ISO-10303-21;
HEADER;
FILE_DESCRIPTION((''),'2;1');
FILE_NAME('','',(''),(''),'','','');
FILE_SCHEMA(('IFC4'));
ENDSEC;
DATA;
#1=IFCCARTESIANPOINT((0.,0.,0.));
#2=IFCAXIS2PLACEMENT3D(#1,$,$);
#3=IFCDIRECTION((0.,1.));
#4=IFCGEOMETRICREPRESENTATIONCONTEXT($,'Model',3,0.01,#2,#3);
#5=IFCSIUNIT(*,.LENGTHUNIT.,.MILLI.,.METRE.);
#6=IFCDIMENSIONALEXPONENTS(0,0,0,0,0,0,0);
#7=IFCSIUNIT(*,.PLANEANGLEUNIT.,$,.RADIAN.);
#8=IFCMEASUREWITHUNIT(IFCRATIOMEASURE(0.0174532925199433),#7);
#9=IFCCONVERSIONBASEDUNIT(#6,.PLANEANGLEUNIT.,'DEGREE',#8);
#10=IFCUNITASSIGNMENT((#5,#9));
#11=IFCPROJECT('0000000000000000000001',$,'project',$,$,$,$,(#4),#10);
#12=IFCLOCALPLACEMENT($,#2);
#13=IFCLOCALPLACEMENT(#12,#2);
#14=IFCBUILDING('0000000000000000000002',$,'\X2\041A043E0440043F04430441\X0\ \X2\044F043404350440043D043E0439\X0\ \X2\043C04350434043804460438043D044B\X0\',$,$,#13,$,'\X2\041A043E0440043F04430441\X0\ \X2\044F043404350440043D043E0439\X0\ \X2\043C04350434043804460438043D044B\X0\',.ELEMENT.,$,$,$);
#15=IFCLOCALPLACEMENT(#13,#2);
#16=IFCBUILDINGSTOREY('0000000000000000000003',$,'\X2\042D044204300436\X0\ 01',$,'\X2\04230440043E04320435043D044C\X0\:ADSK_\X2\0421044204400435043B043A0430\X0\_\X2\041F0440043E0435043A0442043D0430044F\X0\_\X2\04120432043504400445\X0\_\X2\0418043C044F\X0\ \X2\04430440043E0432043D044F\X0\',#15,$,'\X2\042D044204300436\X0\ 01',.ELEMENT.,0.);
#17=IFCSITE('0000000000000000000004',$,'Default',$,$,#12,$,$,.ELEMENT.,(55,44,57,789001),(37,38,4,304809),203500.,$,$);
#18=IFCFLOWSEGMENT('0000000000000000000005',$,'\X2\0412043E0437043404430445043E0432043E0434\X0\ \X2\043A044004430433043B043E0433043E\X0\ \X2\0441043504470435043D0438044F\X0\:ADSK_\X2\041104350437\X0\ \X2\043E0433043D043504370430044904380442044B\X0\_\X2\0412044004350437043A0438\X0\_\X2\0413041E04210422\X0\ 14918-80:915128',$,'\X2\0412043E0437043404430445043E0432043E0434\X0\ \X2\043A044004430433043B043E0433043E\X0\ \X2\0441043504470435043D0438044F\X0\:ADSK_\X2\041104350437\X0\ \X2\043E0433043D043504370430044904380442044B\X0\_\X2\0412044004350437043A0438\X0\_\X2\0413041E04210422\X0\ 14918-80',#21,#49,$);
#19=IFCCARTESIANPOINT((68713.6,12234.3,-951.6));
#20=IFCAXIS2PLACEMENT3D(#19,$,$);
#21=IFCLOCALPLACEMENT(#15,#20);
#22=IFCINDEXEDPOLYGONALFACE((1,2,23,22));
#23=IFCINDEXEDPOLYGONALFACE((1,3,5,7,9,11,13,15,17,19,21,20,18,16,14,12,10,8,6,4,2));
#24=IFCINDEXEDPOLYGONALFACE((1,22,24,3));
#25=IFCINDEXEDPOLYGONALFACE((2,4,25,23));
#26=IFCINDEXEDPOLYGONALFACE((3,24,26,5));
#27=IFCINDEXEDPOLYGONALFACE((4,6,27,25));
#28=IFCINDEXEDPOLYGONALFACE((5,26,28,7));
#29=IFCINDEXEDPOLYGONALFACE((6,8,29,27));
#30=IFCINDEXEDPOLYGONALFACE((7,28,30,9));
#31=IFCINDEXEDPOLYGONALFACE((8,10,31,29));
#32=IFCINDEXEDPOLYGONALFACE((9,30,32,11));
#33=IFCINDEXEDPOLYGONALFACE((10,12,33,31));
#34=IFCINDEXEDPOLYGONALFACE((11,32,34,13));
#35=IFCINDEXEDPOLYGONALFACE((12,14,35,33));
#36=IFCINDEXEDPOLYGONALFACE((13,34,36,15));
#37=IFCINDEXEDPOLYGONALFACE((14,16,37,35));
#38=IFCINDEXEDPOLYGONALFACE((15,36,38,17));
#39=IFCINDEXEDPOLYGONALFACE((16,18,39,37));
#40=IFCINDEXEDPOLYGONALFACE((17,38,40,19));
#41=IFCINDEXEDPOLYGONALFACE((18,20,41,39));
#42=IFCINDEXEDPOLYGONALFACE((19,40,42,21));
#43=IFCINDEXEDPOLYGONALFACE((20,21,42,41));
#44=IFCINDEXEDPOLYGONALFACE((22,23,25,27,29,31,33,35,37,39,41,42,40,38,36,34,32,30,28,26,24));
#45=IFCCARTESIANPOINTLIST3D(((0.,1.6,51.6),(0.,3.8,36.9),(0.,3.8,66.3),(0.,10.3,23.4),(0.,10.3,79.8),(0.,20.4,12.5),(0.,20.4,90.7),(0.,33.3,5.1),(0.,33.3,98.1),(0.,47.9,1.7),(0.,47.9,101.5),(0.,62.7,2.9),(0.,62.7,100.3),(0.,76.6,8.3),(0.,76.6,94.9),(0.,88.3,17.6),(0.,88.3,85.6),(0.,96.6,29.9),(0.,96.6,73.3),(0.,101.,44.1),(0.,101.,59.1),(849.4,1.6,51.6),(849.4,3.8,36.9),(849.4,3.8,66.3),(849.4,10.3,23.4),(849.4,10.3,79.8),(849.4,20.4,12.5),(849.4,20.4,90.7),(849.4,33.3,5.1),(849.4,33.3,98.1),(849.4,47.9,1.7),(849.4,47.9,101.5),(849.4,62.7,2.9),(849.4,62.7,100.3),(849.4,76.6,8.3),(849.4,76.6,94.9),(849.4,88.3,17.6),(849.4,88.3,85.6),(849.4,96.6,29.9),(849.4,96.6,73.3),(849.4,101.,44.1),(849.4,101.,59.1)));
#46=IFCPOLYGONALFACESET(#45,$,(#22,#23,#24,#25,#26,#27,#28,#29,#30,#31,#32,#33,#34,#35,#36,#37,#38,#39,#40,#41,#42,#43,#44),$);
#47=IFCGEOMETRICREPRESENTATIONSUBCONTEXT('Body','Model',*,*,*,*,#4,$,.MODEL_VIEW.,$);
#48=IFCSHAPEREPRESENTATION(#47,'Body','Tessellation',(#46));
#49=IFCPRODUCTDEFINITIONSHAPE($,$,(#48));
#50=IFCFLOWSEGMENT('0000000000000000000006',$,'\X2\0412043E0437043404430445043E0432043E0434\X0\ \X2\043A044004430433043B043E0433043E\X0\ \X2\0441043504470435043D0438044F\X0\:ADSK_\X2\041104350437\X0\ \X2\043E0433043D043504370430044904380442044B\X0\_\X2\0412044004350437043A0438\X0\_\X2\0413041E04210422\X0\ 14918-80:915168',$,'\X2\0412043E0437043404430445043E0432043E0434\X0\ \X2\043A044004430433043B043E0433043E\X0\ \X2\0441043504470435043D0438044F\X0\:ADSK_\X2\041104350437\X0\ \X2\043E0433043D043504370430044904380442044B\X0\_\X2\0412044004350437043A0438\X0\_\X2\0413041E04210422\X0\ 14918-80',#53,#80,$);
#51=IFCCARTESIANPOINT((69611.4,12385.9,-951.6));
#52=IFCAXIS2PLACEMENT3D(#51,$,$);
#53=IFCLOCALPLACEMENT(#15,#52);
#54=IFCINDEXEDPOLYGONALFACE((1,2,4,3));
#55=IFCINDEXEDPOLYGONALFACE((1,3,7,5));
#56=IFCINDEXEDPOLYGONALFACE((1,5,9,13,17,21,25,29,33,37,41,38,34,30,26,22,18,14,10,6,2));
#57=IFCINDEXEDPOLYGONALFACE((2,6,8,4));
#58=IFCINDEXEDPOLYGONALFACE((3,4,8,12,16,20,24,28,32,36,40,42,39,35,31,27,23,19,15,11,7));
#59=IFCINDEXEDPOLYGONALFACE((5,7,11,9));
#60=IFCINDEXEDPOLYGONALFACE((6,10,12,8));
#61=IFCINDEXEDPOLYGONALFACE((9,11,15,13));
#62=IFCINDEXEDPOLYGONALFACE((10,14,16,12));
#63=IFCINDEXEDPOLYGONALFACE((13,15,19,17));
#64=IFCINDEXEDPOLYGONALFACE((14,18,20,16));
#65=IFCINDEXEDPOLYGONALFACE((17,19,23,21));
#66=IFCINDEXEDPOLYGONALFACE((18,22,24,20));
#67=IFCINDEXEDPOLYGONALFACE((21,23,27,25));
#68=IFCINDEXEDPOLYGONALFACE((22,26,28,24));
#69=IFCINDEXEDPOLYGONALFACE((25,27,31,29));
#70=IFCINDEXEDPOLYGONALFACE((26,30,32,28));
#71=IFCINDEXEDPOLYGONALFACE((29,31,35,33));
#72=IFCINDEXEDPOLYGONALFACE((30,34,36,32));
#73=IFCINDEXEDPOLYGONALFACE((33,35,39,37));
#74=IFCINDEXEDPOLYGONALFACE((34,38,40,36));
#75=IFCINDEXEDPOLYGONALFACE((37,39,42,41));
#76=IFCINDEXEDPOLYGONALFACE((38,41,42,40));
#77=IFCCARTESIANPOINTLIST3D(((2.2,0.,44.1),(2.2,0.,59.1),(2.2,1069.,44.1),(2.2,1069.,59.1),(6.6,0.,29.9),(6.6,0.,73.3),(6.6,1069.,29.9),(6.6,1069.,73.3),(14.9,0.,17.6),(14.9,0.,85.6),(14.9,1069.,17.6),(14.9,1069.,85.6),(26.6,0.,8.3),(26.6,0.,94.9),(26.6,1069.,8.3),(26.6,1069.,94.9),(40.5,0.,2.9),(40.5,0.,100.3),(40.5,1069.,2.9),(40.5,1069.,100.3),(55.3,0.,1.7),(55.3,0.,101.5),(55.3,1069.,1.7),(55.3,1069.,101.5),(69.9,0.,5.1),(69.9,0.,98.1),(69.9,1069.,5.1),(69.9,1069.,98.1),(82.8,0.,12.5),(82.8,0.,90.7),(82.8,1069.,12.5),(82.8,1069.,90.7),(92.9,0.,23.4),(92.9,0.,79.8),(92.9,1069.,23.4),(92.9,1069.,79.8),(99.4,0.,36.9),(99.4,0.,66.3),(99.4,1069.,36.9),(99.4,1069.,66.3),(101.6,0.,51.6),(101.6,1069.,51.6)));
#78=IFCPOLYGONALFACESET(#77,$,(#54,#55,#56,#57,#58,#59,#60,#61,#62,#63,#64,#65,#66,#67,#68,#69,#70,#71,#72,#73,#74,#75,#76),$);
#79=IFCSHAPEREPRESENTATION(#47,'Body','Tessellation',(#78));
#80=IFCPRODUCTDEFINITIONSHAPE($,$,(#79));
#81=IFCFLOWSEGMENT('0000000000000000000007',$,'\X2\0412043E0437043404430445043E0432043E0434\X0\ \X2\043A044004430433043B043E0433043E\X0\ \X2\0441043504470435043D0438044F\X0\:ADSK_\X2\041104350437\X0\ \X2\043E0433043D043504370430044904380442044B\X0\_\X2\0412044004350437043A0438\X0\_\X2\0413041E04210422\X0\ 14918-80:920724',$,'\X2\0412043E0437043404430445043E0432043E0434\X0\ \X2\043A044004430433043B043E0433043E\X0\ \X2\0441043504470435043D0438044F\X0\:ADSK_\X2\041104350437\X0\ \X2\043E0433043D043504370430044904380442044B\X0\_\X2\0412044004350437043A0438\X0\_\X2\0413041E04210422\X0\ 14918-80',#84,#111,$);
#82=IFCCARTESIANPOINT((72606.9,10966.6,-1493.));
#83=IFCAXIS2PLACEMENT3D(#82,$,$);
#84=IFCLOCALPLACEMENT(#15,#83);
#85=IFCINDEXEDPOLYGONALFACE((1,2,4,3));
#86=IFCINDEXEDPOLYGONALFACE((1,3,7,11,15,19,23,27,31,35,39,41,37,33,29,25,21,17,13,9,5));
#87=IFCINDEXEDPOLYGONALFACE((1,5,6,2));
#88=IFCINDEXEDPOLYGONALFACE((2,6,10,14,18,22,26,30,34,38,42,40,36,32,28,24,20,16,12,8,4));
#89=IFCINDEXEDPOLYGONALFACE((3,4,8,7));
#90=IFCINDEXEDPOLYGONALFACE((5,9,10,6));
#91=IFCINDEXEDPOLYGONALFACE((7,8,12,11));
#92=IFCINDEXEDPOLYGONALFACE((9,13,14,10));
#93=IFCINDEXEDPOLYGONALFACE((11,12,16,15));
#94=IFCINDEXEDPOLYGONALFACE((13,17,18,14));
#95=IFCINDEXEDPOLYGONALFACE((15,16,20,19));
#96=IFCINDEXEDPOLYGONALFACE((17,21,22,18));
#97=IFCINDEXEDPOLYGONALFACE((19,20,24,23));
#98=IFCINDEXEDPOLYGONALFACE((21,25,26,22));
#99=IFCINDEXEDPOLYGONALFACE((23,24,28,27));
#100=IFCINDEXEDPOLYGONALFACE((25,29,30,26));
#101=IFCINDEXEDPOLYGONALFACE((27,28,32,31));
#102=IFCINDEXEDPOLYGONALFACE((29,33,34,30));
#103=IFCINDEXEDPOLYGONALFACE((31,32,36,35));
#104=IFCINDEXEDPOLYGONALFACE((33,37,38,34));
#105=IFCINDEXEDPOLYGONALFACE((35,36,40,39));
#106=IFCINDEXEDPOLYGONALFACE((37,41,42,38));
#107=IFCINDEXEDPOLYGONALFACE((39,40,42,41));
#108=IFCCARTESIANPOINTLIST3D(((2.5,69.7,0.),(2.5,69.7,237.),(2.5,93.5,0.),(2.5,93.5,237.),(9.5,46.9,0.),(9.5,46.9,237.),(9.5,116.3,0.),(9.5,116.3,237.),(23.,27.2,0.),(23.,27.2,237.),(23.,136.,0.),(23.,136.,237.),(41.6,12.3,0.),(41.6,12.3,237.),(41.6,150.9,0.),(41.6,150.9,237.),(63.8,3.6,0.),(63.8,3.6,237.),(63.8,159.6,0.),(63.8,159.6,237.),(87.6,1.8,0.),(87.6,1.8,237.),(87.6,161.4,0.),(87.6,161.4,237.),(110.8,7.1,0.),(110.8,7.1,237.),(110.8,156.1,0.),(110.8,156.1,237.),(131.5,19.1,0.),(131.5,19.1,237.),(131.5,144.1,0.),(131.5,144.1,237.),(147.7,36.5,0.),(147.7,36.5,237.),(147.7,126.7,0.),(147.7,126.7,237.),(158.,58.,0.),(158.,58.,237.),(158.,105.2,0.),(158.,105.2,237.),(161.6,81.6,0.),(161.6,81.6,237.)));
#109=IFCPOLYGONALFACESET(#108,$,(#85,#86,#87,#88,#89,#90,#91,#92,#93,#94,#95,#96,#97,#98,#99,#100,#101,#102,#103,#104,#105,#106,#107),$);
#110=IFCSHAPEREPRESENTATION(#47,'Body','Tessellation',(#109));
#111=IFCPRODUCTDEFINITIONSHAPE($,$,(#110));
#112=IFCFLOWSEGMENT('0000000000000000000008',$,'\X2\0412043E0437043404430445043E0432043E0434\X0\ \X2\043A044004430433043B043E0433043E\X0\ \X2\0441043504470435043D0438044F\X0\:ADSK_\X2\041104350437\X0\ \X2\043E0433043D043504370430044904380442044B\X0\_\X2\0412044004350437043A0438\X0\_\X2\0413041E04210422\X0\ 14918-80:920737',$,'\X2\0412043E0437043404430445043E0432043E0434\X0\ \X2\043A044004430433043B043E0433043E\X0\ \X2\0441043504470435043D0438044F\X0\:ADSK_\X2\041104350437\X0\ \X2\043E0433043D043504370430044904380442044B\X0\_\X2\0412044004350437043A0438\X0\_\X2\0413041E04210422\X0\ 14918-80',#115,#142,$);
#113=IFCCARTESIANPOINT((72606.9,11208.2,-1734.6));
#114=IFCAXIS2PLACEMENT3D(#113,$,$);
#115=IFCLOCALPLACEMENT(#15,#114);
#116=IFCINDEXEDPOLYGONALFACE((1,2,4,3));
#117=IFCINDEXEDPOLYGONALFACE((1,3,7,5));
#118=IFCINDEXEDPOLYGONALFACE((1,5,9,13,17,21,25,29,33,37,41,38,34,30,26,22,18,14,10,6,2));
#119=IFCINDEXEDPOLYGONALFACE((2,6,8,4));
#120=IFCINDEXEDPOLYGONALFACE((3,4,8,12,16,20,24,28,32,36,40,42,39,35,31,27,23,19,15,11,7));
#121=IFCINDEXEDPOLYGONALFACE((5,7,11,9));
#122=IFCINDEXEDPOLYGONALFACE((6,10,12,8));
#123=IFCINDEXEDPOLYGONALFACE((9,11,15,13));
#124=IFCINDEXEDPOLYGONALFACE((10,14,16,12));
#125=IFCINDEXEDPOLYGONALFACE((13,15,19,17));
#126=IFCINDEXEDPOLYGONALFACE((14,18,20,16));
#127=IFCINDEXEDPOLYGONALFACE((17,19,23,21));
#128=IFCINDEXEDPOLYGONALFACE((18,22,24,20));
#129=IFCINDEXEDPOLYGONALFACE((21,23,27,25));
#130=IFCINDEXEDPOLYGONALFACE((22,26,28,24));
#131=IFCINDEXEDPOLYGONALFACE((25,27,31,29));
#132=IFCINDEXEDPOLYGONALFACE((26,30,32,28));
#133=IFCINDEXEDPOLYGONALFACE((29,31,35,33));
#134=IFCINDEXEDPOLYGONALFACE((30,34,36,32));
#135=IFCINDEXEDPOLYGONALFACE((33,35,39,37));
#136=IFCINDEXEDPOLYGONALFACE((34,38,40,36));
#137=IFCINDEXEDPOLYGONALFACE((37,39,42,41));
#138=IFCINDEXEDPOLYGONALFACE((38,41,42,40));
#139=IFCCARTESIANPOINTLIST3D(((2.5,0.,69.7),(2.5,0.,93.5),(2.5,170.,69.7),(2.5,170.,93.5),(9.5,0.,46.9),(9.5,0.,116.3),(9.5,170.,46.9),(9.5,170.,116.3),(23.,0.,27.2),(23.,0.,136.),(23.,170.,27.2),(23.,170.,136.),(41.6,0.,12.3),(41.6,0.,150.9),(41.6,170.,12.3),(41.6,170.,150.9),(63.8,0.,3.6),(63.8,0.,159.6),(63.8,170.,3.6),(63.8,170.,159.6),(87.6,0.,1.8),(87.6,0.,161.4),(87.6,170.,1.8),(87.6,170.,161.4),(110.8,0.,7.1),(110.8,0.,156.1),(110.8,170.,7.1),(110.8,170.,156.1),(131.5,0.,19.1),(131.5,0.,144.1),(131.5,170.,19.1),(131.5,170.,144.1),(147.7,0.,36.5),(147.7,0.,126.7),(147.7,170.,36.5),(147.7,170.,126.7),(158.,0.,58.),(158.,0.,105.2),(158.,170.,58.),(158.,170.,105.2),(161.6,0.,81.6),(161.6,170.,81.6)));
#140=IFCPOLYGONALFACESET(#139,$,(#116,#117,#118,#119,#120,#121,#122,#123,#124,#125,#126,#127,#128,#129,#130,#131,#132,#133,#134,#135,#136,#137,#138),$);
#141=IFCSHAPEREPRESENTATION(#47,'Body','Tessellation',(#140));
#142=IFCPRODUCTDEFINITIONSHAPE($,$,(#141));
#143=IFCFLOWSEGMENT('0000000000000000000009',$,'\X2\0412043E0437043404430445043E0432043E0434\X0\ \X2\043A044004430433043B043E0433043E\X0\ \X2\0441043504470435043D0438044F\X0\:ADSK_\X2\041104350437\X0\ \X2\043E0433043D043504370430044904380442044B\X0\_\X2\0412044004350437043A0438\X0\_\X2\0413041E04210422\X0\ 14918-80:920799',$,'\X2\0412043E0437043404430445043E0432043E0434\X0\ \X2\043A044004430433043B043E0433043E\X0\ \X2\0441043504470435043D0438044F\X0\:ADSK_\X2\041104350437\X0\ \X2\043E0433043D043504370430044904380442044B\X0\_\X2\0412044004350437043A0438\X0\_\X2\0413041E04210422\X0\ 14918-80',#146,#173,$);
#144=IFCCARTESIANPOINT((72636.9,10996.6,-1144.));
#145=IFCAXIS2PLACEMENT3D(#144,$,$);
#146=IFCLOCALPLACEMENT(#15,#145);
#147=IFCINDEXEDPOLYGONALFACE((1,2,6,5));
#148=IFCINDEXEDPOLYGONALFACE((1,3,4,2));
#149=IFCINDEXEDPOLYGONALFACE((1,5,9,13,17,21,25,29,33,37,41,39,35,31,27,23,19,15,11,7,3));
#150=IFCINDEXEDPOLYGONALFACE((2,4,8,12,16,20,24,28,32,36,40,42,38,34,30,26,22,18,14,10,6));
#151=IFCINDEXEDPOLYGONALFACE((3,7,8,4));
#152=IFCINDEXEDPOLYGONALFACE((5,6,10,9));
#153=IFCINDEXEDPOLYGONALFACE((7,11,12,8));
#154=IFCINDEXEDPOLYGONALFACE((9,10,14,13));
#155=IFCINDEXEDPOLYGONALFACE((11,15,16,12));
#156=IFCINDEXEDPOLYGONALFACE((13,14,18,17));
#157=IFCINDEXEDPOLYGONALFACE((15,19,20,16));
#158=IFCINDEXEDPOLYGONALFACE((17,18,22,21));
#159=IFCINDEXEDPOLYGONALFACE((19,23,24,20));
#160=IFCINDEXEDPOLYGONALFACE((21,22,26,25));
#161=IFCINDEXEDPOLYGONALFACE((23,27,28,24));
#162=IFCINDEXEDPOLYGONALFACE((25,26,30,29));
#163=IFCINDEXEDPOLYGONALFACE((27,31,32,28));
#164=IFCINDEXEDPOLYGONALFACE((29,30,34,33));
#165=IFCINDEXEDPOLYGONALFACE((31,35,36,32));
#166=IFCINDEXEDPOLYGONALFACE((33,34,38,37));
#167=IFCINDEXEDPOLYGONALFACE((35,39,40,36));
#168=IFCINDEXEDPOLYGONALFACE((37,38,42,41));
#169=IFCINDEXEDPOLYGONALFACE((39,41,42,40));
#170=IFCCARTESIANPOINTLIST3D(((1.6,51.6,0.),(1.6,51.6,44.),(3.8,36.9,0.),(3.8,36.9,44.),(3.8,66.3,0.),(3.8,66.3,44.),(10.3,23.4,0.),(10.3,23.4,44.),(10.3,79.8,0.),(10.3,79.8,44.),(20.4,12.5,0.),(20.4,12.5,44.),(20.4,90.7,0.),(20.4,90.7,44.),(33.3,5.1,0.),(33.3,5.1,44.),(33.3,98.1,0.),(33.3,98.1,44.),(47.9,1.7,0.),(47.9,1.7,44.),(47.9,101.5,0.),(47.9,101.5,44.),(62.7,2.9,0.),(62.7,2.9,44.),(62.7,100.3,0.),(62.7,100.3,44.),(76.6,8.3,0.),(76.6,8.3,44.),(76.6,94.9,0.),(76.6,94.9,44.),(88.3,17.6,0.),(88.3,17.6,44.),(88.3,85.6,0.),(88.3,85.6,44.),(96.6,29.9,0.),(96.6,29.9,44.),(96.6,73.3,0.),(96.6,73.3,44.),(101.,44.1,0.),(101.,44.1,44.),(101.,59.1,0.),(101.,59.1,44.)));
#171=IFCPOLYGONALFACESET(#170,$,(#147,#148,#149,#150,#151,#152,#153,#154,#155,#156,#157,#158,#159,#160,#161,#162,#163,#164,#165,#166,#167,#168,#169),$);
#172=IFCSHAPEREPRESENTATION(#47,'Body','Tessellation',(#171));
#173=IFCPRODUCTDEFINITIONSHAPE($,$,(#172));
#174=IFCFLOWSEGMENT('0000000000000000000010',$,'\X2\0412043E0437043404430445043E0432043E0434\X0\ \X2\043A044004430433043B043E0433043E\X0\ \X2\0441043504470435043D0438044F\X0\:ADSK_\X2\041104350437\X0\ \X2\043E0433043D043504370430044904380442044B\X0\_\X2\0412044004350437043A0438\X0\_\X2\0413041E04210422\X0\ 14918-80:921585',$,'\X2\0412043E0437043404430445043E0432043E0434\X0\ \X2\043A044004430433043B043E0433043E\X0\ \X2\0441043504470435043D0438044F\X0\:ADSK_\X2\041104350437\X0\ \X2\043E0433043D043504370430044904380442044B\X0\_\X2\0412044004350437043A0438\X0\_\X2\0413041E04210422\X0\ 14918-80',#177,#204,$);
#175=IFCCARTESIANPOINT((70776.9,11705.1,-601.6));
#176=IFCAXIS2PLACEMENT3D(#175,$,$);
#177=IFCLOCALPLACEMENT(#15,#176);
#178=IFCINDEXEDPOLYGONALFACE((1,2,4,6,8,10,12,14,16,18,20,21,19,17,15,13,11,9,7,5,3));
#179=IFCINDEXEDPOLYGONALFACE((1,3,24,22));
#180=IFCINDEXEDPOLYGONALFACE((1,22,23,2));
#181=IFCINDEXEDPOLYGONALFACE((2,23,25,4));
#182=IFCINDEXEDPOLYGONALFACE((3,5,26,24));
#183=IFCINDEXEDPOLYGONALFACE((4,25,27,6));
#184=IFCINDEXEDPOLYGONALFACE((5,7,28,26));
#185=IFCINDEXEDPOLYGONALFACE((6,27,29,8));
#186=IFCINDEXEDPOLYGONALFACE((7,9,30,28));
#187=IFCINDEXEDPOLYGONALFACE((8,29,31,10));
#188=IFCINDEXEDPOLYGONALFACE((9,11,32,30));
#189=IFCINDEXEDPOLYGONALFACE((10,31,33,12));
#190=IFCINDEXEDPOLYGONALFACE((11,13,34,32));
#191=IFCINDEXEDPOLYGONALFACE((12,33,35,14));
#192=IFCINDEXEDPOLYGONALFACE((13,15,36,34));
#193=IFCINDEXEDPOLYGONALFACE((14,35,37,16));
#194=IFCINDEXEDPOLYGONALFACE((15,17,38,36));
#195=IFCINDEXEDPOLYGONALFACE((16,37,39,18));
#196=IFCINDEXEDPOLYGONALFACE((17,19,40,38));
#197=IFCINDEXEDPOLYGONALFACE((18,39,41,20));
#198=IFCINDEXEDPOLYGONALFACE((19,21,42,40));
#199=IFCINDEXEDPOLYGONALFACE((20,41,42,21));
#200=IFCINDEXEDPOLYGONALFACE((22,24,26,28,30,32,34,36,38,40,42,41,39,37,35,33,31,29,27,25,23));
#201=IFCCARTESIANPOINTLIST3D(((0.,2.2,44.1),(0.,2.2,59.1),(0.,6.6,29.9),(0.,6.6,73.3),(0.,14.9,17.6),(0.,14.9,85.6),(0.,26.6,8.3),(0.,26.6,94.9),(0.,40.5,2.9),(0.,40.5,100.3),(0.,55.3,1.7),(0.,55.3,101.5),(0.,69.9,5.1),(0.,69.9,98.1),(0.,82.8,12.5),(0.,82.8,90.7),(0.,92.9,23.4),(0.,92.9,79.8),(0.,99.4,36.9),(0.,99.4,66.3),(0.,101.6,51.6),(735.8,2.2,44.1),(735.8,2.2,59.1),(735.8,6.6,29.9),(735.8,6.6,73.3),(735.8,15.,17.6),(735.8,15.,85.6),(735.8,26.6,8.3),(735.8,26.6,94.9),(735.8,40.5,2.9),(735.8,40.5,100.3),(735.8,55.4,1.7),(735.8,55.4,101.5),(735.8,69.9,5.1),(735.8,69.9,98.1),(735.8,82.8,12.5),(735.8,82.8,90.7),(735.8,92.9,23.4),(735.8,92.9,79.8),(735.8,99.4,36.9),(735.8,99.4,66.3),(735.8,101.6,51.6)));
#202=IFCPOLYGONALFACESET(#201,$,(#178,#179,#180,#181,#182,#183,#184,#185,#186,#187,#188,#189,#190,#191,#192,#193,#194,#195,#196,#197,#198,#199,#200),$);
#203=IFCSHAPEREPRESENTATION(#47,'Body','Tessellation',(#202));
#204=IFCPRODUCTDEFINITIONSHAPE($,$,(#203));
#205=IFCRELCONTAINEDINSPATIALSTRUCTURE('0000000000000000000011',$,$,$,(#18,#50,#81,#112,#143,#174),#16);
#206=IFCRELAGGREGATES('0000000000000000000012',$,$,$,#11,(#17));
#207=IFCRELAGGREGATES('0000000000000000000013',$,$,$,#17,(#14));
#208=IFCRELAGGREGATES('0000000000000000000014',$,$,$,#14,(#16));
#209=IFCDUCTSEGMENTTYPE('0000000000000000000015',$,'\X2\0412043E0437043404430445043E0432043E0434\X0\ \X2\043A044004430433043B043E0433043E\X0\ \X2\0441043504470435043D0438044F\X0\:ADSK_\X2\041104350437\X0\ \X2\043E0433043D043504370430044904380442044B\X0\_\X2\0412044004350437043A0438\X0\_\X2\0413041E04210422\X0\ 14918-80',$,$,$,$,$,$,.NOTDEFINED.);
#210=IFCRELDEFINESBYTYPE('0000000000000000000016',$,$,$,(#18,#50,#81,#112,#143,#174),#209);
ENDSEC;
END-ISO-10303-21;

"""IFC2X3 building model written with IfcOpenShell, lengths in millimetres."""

from ifc_helpers import new_model, entity, si_unit, converted_unit, direction, frame, origin, origin_2d_with_axis, place, context, subcontext, project, spatial, circle, extrude, type_object, element, save


model = new_model("IFC2X3")

# Units and contexts
model_context = context("Model", 3, precision=0.01, world=origin(), true_north=direction((0.0, 1.0)))
body_context = subcontext(model_context, "Body", "Model", "MODEL_VIEW")
ifc_project = project(units=[si_unit("LENGTHUNIT", "METRE", prefix="MILLI"), converted_unit("PLANEANGLEUNIT", "DEGREE", entity("IfcRatioMeasure", 0.0174532925199433), si_unit("PLANEANGLEUNIT", "RADIAN"), dimensions=[0, 0, 0, 0, 0, 0, 0])], contexts=[model_context])

# Site, building, storey
site_placement = place(None, origin())
site = spatial("IfcSite", under=ifc_project, at=site_placement, Name="Default", CompositionType="ELEMENT", RefLatitude=(55, 44, 57, 789001), RefLongitude=(37, 38, 4, 304809), RefElevation=203500.0)
building_placement = place(site_placement, origin())
building = spatial("IfcBuilding", under=site, at=building_placement, Name="Корпус ядерной медицины", LongName="Корпус ядерной медицины", CompositionType="ELEMENT")
storey_placement = place(building_placement, origin())
storey = spatial("IfcBuildingStorey", under=building, at=storey_placement, Name="Этаж 01", ObjectType="Уровень:ADSK_Стрелка_Проектная_Вверх_Имя уровня", LongName="Этаж 01", CompositionType="ELEMENT", Elevation=0.0)

# Flow segments
duct_segment_type_1 = type_object("IfcDuctSegmentType", Name="Воздуховод круглого сечения:ADSK_Без огнезащиты_Врезки_ГОСТ 14918-80", PredefinedType="NOTDEFINED")
flow_segment_1_placement = place(storey_placement, frame((68713.6, 12234.3, -951.6)))
element("IfcFlowSegment", 1, at=flow_segment_1_placement, inside=storey, type_object=duct_segment_type_1, Name="Воздуховод круглого сечения:ADSK_Без огнезащиты_Врезки_ГОСТ 14918-80:915128", ObjectType="Воздуховод круглого сечения:ADSK_Без огнезащиты_Врезки_ГОСТ 14918-80", context=body_context, shape_type="SweptSolid", body=[
    extrude(circle(Radius=50.0, at=origin_2d_with_axis()), frame((0.0, 51.6, 51.6), z_axis=(1.0, 0.0, 0.0), x_axis=(0.0, -1.0, 0.0)), (0.0, 0.0, 1.0), 849.4),
])
flow_segment_2_placement = place(storey_placement, frame((69611.4, 12385.9, -951.6)))
element("IfcFlowSegment", 2, at=flow_segment_2_placement, inside=storey, type_object=duct_segment_type_1, Name="Воздуховод круглого сечения:ADSK_Без огнезащиты_Врезки_ГОСТ 14918-80:915168", ObjectType="Воздуховод круглого сечения:ADSK_Без огнезащиты_Врезки_ГОСТ 14918-80", context=body_context, shape_type="SweptSolid", body=[
    extrude(circle(Radius=50.0, at=origin_2d_with_axis()), frame((51.6, 0.0, 51.6), z_axis=(0.0, 1.0, 0.0), x_axis=(1.0, 0.0, 0.0)), (0.0, 0.0, 1.0), 1069.0),
])
flow_segment_3_placement = place(storey_placement, frame((72606.9, 10966.6, -1493.0)))
element("IfcFlowSegment", 3, at=flow_segment_3_placement, inside=storey, type_object=duct_segment_type_1, Name="Воздуховод круглого сечения:ADSK_Без огнезащиты_Врезки_ГОСТ 14918-80:920724", ObjectType="Воздуховод круглого сечения:ADSK_Без огнезащиты_Врезки_ГОСТ 14918-80", context=body_context, shape_type="SweptSolid", body=[
    extrude(circle(Radius=80.0, at=origin_2d_with_axis()), frame((81.6, 81.6, 0.0)), (0.0, 0.0, 1.0), 237.0),
])
flow_segment_4_placement = place(storey_placement, frame((72606.9, 11208.2, -1734.6)))
element("IfcFlowSegment", 4, at=flow_segment_4_placement, inside=storey, type_object=duct_segment_type_1, Name="Воздуховод круглого сечения:ADSK_Без огнезащиты_Врезки_ГОСТ 14918-80:920737", ObjectType="Воздуховод круглого сечения:ADSK_Без огнезащиты_Врезки_ГОСТ 14918-80", context=body_context, shape_type="SweptSolid", body=[
    extrude(circle(Radius=80.0, at=origin_2d_with_axis()), frame((81.6, 0.0, 81.6), z_axis=(0.0, 1.0, 0.0), x_axis=(1.0, 0.0, 0.0)), (0.0, 0.0, 1.0), 170.0),
])
flow_segment_5_placement = place(storey_placement, frame((72636.9, 10996.6, -1144.0)))
element("IfcFlowSegment", 5, at=flow_segment_5_placement, inside=storey, type_object=duct_segment_type_1, Name="Воздуховод круглого сечения:ADSK_Без огнезащиты_Врезки_ГОСТ 14918-80:920799", ObjectType="Воздуховод круглого сечения:ADSK_Без огнезащиты_Врезки_ГОСТ 14918-80", context=body_context, shape_type="SweptSolid", body=[
    extrude(circle(Radius=50.0, at=origin_2d_with_axis()), frame((51.6, 51.6, 0.0), z_axis=(0.0, 0.0, 1.0), x_axis=(-1.0, 0.0, 0.0)), (0.0, 0.0, 1.0), 44.0),
])
flow_segment_6_placement = place(storey_placement, frame((70776.9, 11705.1, -601.6)))
element("IfcFlowSegment", 6, at=flow_segment_6_placement, inside=storey, type_object=duct_segment_type_1, Name="Воздуховод круглого сечения:ADSK_Без огнезащиты_Врезки_ГОСТ 14918-80:921585", ObjectType="Воздуховод круглого сечения:ADSK_Без огнезащиты_Врезки_ГОСТ 14918-80", context=body_context, shape_type="SweptSolid", body=[
    extrude(circle(Radius=50.0, at=origin_2d_with_axis()), frame((0.0, 51.6, 51.6), z_axis=(1.0, 0.000019, 0.0), x_axis=(-0.000019, 1.0, 0.0)), (0.0, 0.0, 1.0), 735.8),
])

save(model, "model.ifc")
